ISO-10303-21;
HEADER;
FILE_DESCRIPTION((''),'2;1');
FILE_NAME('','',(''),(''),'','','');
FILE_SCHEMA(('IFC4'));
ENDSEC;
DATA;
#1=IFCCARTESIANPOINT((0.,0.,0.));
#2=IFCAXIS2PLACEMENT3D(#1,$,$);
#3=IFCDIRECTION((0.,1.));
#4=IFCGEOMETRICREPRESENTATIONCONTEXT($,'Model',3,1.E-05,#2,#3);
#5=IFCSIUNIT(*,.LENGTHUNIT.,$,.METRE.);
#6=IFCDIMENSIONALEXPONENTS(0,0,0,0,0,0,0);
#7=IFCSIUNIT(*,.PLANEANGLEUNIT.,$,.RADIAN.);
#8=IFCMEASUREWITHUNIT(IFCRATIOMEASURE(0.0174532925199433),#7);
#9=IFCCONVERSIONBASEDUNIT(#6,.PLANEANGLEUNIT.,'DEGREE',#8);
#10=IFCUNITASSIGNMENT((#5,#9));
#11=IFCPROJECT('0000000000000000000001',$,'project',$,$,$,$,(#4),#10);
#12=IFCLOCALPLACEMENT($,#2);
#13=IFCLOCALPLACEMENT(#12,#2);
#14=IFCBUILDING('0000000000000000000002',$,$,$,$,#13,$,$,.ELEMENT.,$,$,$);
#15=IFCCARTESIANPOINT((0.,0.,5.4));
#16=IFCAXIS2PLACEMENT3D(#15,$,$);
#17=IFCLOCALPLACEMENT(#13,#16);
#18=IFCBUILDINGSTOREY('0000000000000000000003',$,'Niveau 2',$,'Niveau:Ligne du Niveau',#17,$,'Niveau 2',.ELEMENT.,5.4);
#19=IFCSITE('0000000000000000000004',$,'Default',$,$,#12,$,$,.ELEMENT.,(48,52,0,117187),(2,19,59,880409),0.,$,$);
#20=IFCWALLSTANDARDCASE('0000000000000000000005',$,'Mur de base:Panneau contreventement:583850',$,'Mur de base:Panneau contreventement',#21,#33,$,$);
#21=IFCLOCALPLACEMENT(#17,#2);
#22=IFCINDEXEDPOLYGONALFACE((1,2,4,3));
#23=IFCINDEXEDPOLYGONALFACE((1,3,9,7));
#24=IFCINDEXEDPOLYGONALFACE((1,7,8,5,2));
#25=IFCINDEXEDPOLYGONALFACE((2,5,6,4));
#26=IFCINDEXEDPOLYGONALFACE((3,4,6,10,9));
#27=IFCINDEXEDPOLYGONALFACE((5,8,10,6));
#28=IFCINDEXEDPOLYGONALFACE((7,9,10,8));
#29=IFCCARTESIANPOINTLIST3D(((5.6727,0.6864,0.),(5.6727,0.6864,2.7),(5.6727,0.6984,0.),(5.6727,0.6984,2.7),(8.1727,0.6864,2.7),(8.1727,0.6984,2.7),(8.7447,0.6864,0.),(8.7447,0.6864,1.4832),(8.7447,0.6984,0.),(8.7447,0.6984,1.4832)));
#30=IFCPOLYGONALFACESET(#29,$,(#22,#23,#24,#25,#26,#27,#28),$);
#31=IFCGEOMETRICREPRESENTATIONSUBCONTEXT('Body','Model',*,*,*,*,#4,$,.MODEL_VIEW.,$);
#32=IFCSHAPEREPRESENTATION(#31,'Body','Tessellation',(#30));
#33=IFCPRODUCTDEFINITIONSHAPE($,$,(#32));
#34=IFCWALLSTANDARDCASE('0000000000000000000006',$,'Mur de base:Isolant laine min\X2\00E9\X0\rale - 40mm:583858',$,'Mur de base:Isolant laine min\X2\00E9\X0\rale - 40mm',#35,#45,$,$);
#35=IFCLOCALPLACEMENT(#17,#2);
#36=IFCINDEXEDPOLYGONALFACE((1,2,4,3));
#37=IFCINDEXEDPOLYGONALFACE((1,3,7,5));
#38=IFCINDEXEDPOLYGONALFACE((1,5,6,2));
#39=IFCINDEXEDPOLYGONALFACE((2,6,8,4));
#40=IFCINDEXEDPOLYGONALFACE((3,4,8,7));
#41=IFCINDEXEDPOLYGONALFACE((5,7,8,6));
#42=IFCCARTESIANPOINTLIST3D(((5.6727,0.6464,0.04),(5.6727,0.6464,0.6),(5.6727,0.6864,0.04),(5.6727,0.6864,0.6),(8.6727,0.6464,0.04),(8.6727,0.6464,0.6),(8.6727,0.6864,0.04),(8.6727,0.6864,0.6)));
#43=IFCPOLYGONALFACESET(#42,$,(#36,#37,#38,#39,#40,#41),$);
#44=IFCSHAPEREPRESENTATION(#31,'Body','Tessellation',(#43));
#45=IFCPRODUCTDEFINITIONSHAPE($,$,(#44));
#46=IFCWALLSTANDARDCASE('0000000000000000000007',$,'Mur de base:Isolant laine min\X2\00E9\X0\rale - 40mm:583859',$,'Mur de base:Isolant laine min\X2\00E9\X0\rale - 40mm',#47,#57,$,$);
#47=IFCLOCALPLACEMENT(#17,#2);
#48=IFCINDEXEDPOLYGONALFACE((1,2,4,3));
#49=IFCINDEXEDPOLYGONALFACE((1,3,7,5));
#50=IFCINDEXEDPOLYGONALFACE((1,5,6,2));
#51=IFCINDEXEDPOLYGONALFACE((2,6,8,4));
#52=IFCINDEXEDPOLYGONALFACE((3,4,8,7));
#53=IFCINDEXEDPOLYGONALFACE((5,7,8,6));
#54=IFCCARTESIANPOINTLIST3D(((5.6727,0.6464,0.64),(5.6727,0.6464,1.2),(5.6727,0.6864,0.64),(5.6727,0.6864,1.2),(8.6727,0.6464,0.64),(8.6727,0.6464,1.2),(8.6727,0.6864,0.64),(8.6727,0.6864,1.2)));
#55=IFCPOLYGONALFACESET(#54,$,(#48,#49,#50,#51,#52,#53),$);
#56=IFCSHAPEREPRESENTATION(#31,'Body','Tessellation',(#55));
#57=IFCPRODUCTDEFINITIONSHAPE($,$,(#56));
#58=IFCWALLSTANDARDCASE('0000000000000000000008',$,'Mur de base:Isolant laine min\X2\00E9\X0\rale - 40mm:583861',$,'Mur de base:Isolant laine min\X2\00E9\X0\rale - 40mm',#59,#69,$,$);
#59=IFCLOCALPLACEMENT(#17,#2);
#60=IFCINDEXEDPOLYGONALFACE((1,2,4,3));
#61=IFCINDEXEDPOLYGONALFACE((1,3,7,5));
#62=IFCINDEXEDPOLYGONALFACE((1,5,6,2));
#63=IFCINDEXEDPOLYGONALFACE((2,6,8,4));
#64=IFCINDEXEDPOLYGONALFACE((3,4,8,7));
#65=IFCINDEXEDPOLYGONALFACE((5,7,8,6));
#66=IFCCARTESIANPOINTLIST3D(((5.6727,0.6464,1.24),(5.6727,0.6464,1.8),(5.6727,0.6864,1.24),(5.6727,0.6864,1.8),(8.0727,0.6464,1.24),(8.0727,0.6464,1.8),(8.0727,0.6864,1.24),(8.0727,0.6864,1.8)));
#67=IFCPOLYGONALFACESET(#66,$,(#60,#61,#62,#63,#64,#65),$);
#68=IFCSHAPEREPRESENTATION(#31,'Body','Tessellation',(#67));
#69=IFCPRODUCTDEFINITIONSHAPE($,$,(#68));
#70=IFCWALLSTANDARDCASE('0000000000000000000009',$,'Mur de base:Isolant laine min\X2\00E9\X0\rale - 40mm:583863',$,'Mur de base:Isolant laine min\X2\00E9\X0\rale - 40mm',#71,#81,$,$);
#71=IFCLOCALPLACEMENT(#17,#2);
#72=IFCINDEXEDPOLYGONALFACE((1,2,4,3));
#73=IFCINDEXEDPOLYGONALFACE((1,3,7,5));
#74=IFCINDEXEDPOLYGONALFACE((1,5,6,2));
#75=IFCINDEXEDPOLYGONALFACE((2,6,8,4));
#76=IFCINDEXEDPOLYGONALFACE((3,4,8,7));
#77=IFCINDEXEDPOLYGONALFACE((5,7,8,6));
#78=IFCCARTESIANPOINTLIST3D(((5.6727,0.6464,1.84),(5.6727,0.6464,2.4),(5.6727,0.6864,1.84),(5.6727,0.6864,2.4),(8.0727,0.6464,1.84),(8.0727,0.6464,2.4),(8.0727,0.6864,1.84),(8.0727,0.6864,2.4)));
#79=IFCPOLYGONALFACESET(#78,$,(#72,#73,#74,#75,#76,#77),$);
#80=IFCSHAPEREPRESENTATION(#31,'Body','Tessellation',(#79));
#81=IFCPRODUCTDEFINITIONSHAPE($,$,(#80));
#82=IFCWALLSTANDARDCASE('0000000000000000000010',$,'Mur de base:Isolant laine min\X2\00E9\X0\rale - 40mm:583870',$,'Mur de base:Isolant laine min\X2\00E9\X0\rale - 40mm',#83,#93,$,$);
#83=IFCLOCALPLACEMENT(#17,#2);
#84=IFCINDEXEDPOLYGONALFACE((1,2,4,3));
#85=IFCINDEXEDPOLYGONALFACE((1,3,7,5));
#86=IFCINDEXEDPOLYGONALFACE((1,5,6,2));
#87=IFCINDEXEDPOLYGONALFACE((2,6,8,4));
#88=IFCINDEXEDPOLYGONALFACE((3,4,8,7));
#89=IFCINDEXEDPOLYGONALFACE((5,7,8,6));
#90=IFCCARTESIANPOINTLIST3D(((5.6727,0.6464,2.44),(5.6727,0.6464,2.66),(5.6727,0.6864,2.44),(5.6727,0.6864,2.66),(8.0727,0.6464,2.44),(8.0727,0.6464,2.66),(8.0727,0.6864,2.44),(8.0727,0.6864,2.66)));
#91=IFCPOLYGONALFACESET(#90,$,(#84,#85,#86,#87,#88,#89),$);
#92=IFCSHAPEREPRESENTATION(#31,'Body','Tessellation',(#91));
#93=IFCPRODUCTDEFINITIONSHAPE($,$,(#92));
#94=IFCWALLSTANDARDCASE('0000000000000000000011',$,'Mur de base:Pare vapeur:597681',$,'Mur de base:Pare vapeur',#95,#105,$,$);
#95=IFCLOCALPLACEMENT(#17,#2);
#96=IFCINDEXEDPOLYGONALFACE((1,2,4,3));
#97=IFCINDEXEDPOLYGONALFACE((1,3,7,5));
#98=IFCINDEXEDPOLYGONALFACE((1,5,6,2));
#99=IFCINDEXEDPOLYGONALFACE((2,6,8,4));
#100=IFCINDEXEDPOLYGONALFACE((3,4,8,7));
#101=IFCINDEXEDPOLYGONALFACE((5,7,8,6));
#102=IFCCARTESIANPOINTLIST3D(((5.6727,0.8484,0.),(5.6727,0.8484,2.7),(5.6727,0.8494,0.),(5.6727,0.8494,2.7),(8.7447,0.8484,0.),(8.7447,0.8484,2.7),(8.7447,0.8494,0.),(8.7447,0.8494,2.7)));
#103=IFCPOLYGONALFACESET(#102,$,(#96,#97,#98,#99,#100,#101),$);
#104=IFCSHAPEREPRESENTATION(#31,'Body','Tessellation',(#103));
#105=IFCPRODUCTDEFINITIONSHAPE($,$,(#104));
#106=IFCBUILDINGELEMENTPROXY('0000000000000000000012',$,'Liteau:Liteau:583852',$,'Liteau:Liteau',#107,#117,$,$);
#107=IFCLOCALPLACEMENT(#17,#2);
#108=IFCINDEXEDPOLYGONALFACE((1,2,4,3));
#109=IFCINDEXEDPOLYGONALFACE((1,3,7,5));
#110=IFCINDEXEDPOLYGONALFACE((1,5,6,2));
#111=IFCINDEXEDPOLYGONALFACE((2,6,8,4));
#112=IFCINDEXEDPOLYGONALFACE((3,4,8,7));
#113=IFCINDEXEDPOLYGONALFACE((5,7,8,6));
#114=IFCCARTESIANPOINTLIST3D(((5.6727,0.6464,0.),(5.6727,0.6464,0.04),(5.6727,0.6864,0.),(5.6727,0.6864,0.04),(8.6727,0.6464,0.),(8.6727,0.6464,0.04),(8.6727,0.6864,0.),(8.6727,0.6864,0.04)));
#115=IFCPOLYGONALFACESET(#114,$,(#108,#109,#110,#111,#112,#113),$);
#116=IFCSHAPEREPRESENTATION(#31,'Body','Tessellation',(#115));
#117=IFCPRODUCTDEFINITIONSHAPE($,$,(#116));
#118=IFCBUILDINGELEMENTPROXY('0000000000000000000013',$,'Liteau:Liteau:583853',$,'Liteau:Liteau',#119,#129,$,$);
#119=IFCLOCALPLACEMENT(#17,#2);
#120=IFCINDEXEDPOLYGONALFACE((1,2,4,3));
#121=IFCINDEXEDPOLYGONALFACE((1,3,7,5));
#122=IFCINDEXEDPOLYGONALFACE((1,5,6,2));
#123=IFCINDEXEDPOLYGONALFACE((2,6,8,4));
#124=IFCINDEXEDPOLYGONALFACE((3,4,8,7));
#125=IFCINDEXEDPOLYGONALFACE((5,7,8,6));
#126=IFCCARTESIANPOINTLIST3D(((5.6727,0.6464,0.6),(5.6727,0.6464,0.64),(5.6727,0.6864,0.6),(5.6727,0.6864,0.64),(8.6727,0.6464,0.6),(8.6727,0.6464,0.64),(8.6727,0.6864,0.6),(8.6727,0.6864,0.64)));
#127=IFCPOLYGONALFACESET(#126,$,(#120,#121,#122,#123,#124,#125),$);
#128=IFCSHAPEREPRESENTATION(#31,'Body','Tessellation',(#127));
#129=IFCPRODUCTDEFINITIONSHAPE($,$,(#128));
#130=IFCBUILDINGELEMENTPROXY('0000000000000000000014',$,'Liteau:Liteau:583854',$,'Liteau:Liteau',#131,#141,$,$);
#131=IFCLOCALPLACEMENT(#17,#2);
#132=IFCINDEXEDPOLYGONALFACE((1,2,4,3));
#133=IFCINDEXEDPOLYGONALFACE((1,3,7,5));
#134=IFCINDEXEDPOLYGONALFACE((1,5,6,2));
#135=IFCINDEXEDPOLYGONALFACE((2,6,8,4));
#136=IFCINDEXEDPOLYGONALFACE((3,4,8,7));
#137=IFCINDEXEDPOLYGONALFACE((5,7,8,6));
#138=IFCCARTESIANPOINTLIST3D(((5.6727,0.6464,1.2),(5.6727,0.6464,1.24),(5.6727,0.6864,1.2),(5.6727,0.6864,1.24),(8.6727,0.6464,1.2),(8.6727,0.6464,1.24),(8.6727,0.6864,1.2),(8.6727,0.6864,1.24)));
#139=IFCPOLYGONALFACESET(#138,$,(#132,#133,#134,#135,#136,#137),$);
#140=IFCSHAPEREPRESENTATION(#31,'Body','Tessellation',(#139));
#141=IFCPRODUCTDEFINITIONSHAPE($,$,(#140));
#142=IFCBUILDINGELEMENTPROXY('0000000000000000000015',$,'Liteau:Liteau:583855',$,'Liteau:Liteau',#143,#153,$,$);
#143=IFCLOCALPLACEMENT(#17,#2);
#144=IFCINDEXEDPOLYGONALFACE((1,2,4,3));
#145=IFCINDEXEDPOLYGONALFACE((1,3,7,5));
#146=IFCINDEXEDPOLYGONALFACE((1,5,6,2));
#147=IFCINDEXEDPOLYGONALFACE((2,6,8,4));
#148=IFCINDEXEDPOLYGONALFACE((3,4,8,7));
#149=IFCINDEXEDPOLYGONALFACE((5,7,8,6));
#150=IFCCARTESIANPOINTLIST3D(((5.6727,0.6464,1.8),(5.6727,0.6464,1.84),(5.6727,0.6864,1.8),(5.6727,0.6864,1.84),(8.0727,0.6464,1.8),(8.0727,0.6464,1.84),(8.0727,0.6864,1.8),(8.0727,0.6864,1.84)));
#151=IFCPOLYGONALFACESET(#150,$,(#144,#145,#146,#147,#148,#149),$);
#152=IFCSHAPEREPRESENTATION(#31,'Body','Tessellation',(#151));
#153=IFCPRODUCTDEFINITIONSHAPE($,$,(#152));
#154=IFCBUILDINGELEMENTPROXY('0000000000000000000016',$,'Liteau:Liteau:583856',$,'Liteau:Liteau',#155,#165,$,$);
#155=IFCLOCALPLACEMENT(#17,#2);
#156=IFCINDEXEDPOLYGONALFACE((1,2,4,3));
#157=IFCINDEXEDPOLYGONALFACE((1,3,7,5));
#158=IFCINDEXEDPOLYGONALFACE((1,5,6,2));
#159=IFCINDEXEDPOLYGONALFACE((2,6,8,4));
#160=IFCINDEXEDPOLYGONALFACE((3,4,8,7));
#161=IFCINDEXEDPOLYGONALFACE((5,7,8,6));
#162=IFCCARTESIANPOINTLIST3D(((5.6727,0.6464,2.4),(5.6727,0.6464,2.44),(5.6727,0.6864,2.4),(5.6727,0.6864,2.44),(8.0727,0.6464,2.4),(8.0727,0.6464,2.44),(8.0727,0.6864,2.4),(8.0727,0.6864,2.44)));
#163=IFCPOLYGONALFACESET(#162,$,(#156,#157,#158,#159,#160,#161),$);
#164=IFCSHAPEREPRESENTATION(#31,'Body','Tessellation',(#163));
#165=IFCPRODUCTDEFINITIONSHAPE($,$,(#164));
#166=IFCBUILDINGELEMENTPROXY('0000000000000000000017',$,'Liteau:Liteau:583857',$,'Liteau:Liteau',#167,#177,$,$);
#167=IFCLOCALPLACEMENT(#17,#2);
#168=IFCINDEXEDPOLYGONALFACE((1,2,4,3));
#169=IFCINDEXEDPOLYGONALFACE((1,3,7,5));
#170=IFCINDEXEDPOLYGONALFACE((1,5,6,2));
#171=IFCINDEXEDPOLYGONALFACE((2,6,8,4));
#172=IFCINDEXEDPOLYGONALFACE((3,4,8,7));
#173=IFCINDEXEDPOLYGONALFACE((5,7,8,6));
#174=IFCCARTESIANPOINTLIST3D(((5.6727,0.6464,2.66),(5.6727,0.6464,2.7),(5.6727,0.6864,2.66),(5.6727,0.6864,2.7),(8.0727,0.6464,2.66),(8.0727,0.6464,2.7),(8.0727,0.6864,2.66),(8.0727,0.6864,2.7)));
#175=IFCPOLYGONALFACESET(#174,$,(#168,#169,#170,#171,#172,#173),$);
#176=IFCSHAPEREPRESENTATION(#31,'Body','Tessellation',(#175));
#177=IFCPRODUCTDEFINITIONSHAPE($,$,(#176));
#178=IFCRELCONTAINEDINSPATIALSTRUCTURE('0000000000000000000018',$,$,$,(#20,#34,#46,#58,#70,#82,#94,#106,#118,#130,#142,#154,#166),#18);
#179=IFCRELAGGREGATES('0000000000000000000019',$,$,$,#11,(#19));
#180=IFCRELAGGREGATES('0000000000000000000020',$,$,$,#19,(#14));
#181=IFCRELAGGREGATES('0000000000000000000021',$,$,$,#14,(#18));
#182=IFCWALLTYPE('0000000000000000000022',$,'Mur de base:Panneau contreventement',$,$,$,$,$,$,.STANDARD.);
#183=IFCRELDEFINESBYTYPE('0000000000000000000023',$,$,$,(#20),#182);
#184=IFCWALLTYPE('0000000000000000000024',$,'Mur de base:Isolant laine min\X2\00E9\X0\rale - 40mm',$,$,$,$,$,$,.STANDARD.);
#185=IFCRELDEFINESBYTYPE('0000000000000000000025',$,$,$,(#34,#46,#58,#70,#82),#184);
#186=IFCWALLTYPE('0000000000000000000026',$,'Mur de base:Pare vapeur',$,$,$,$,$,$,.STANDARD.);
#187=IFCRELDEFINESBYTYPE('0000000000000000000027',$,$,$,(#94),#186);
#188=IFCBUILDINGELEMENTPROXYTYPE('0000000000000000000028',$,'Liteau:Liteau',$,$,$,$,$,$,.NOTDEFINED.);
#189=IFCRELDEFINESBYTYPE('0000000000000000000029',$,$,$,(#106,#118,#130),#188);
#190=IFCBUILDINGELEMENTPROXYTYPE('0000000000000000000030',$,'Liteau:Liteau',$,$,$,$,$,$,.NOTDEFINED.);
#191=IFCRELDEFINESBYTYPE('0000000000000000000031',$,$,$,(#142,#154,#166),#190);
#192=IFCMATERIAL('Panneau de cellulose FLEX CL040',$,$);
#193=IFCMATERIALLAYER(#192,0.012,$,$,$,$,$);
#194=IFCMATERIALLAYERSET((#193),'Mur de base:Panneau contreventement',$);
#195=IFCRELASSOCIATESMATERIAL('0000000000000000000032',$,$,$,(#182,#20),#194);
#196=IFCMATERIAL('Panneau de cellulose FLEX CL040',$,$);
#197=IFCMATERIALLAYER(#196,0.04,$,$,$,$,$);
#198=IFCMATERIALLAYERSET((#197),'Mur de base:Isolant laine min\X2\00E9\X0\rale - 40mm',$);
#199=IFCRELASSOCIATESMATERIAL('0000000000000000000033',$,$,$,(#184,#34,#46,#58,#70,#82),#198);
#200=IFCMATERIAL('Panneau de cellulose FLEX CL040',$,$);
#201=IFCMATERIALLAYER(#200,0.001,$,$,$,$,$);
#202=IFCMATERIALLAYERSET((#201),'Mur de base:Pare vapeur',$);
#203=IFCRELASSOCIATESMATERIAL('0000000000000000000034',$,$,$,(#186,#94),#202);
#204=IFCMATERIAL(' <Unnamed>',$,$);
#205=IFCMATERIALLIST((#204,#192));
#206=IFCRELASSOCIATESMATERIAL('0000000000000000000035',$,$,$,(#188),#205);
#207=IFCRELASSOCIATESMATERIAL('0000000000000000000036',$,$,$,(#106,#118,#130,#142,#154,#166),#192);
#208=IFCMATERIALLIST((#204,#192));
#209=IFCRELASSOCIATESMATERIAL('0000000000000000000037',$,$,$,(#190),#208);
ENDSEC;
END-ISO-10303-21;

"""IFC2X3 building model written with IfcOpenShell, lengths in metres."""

from ifc_helpers import new_model, entity, si_unit, converted_unit, direction, frame, frame_2d, origin, origin_2d_with_axis, place, context, subcontext, project, spatial, rectangle, extrude, clip, halfspace, source, transform, mapped, material, material_list, layer, layer_set, layer_usage, type_object, type_shapes, element, save


model = new_model("IFC2X3")

# Units and contexts
model_context = context("Model", 3, precision=1e-05, world=origin(), true_north=direction((0.0, 1.0)))
body_context = subcontext(model_context, "Body", "Model", "MODEL_VIEW")
ifc_project = project(units=[si_unit("LENGTHUNIT", "METRE"), converted_unit("PLANEANGLEUNIT", "DEGREE", entity("IfcRatioMeasure", 0.0174532925199433), si_unit("PLANEANGLEUNIT", "RADIAN"), dimensions=[0, 0, 0, 0, 0, 0, 0])], contexts=[model_context])

# Site, building, storey
site_placement = place(None, origin())
site = spatial("IfcSite", under=ifc_project, at=site_placement, Name="Default", CompositionType="ELEMENT", RefLatitude=(48, 52, 0, 117187), RefLongitude=(2, 19, 59, 880409), RefElevation=0.0)
building_placement = place(site_placement, origin())
building = spatial("IfcBuilding", under=site, at=building_placement, CompositionType="ELEMENT")
storey_placement = place(building_placement, frame((0.0, 0.0, 5.4)))
storey = spatial("IfcBuildingStorey", under=building, at=storey_placement, Name="Niveau 2", ObjectType="Niveau:Ligne du Niveau", LongName="Niveau 2", CompositionType="ELEMENT", Elevation=5.4)

# Shared definitions
ifc_material_1 = material(Name="Panneau de cellulose FLEX CL040")

# Walls
ifc_layer_1 = layer(ifc_material_1, 0.012)
ifc_layer_set_1 = layer_set([ifc_layer_1], Name="Mur de base:Panneau contreventement")
ifc_layer_usage_1 = layer_usage(ifc_layer_set_1, "AXIS2", "NEGATIVE", 0.006)
wall_type_1 = type_object("IfcWallType", Name="Mur de base:Panneau contreventement", PredefinedType="STANDARD", material=ifc_layer_set_1)
wall_1_placement = place(storey_placement, frame((5.6727, 0.6924, 0.0)))
element("IfcWallStandardCase", 1, at=wall_1_placement, inside=storey, type_object=wall_type_1, material=ifc_layer_usage_1, Name="Mur de base:Panneau contreventement:583850", ObjectType="Mur de base:Panneau contreventement", context=body_context, shape_type="Clipping", body=[
    clip(extrude(rectangle(XDim=3.072, YDim=0.012, at=frame_2d((1.536, 0.0), x_axis=(-1.0, 0.0))), origin(), (0.0, 0.0, 1.0), 2.7), halfspace(frame((2.5, -0.006, 2.7), z_axis=(0.904996, 0.0, 0.425419), x_axis=(0.0, 1.0, 0.0)), False)),
])
ifc_material_2 = material(Name="Panneau de cellulose FLEX CL040")
ifc_layer_2 = layer(ifc_material_2, 0.04)
ifc_layer_set_2 = layer_set([ifc_layer_2], Name="Mur de base:Isolant laine minérale - 40mm")
ifc_layer_usage_2 = layer_usage(ifc_layer_set_2, "AXIS2", "NEGATIVE", 0.02)
wall_type_2 = type_object("IfcWallType", Name="Mur de base:Isolant laine minérale - 40mm", PredefinedType="STANDARD", material=ifc_layer_set_2)
wall_2_placement = place(storey_placement, frame((5.6727, 0.6664, 0.04)))
element("IfcWallStandardCase", 2, at=wall_2_placement, inside=storey, type_object=wall_type_2, material=ifc_layer_usage_2, Name="Mur de base:Isolant laine minérale - 40mm:583858", ObjectType="Mur de base:Isolant laine minérale - 40mm", context=body_context, shape_type="SweptSolid", body=[
    extrude(rectangle(XDim=3.0, YDim=0.04, at=frame_2d((1.5, 0.0), x_axis=(-1.0, 0.0))), origin(), (0.0, 0.0, 1.0), 0.56),
])
ifc_layer_usage_3 = layer_usage(ifc_layer_set_2, "AXIS2", "NEGATIVE", 0.02)
wall_3_placement = place(storey_placement, frame((5.6727, 0.6664, 0.64)))
element("IfcWallStandardCase", 3, at=wall_3_placement, inside=storey, type_object=wall_type_2, material=ifc_layer_usage_3, Name="Mur de base:Isolant laine minérale - 40mm:583859", ObjectType="Mur de base:Isolant laine minérale - 40mm", context=body_context, shape_type="SweptSolid", body=[
    extrude(rectangle(XDim=3.0, YDim=0.04, at=frame_2d((1.5, 0.0), x_axis=(-1.0, 0.0))), origin(), (0.0, 0.0, 1.0), 0.56),
])
ifc_layer_usage_4 = layer_usage(ifc_layer_set_2, "AXIS2", "NEGATIVE", 0.02)
wall_4_placement = place(storey_placement, frame((5.6727, 0.6664, 1.24)))
element("IfcWallStandardCase", 4, at=wall_4_placement, inside=storey, type_object=wall_type_2, material=ifc_layer_usage_4, Name="Mur de base:Isolant laine minérale - 40mm:583861", ObjectType="Mur de base:Isolant laine minérale - 40mm", context=body_context, shape_type="SweptSolid", body=[
    extrude(rectangle(XDim=2.4, YDim=0.04, at=frame_2d((1.2, 0.0), x_axis=(-1.0, 0.0))), origin(), (0.0, 0.0, 1.0), 0.56),
])
ifc_layer_usage_5 = layer_usage(ifc_layer_set_2, "AXIS2", "NEGATIVE", 0.02)
wall_5_placement = place(storey_placement, frame((5.6727, 0.6664, 1.84)))
element("IfcWallStandardCase", 5, at=wall_5_placement, inside=storey, type_object=wall_type_2, material=ifc_layer_usage_5, Name="Mur de base:Isolant laine minérale - 40mm:583863", ObjectType="Mur de base:Isolant laine minérale - 40mm", context=body_context, shape_type="SweptSolid", body=[
    extrude(rectangle(XDim=2.4, YDim=0.04, at=frame_2d((1.2, 0.0), x_axis=(-1.0, 0.0))), origin(), (0.0, 0.0, 1.0), 0.56),
])
ifc_layer_usage_6 = layer_usage(ifc_layer_set_2, "AXIS2", "NEGATIVE", 0.02)
wall_6_placement = place(storey_placement, frame((5.6727, 0.6664, 2.44)))
element("IfcWallStandardCase", 6, at=wall_6_placement, inside=storey, type_object=wall_type_2, material=ifc_layer_usage_6, Name="Mur de base:Isolant laine minérale - 40mm:583870", ObjectType="Mur de base:Isolant laine minérale - 40mm", context=body_context, shape_type="SweptSolid", body=[
    extrude(rectangle(XDim=2.4, YDim=0.04, at=frame_2d((1.2, 0.0), x_axis=(-1.0, 0.0))), origin(), (0.0, 0.0, 1.0), 0.22),
])
ifc_material_3 = material(Name="Panneau de cellulose FLEX CL040")
ifc_layer_3 = layer(ifc_material_3, 0.001)
ifc_layer_set_3 = layer_set([ifc_layer_3], Name="Mur de base:Pare vapeur")
ifc_layer_usage_7 = layer_usage(ifc_layer_set_3, "AXIS2", "NEGATIVE", 0.0005)
wall_type_3 = type_object("IfcWallType", Name="Mur de base:Pare vapeur", PredefinedType="STANDARD", material=ifc_layer_set_3)
wall_7_placement = place(storey_placement, frame((5.6727, 0.8489, 0.0)))
element("IfcWallStandardCase", 7, at=wall_7_placement, inside=storey, type_object=wall_type_3, material=ifc_layer_usage_7, Name="Mur de base:Pare vapeur:597681", ObjectType="Mur de base:Pare vapeur", context=body_context, shape_type="SweptSolid", body=[
    extrude(rectangle(XDim=3.072, YDim=0.001, at=frame_2d((1.536, 0.0), x_axis=(-1.0, 0.0))), origin(), (0.0, 0.0, 1.0), 2.7),
])

# Building element proxies
ifc_material_4 = material(Name=" <Unnamed>")
ifc_material_list_1 = material_list([ifc_material_4, ifc_material_1])
building_element_proxy_type_1 = type_object("IfcBuildingElementProxyType", Name="Liteau:Liteau", PredefinedType="NOTDEFINED", material=ifc_material_list_1)
shared_shape_1 = source(origin(), body_context, "Body", "SweptSolid", [
    extrude(rectangle(XDim=3.0, YDim=0.04, at=origin_2d_with_axis()), frame((1.5, -0.02, 0.0), z_axis=(0.0, 0.0, 1.0), x_axis=(-1.0, 0.0, 0.0)), (0.0, 0.0, 1.0), 0.04),
])
type_shapes(building_element_proxy_type_1, [shared_shape_1])
for number, where, name in (
    (8, (5.6727, 0.6864, 0.0), "Liteau:Liteau:583852"),
    (9, (5.6727, 0.6864, 0.6), "Liteau:Liteau:583853"),
    (10, (5.6727, 0.6864, 1.2), "Liteau:Liteau:583854"),
):
    element("IfcBuildingElementProxy", number, at=place(storey_placement, frame(where)), inside=storey, type_object=building_element_proxy_type_1, material=ifc_material_1, Name=name, ObjectType="Liteau:Liteau", context=body_context, shape_type="MappedRepresentation", body=[
        mapped(shared_shape_1, transform((0.0, 0.0, 0.0), scale=1.0)),
    ])
ifc_material_list_2 = material_list([ifc_material_4, ifc_material_1])
building_element_proxy_type_2 = type_object("IfcBuildingElementProxyType", Name="Liteau:Liteau", PredefinedType="NOTDEFINED", material=ifc_material_list_2)
shared_shape_2 = source(origin(), body_context, "Body", "SweptSolid", [
    extrude(rectangle(XDim=2.4, YDim=0.04, at=origin_2d_with_axis()), frame((1.2, -0.02, 0.0), z_axis=(0.0, 0.0, 1.0), x_axis=(-1.0, 0.0, 0.0)), (0.0, 0.0, 1.0), 0.04),
])
type_shapes(building_element_proxy_type_2, [shared_shape_2])
for number, where, name in (
    (11, (5.6727, 0.6864, 1.8), "Liteau:Liteau:583855"),
    (12, (5.6727, 0.6864, 2.4), "Liteau:Liteau:583856"),
    (13, (5.6727, 0.6864, 2.66), "Liteau:Liteau:583857"),
):
    element("IfcBuildingElementProxy", number, at=place(storey_placement, frame(where)), inside=storey, type_object=building_element_proxy_type_2, material=ifc_material_1, Name=name, ObjectType="Liteau:Liteau", context=body_context, shape_type="MappedRepresentation", body=[
        mapped(shared_shape_2, transform((0.0, 0.0, 0.0), scale=1.0)),
    ])

save(model, "model.ifc")
